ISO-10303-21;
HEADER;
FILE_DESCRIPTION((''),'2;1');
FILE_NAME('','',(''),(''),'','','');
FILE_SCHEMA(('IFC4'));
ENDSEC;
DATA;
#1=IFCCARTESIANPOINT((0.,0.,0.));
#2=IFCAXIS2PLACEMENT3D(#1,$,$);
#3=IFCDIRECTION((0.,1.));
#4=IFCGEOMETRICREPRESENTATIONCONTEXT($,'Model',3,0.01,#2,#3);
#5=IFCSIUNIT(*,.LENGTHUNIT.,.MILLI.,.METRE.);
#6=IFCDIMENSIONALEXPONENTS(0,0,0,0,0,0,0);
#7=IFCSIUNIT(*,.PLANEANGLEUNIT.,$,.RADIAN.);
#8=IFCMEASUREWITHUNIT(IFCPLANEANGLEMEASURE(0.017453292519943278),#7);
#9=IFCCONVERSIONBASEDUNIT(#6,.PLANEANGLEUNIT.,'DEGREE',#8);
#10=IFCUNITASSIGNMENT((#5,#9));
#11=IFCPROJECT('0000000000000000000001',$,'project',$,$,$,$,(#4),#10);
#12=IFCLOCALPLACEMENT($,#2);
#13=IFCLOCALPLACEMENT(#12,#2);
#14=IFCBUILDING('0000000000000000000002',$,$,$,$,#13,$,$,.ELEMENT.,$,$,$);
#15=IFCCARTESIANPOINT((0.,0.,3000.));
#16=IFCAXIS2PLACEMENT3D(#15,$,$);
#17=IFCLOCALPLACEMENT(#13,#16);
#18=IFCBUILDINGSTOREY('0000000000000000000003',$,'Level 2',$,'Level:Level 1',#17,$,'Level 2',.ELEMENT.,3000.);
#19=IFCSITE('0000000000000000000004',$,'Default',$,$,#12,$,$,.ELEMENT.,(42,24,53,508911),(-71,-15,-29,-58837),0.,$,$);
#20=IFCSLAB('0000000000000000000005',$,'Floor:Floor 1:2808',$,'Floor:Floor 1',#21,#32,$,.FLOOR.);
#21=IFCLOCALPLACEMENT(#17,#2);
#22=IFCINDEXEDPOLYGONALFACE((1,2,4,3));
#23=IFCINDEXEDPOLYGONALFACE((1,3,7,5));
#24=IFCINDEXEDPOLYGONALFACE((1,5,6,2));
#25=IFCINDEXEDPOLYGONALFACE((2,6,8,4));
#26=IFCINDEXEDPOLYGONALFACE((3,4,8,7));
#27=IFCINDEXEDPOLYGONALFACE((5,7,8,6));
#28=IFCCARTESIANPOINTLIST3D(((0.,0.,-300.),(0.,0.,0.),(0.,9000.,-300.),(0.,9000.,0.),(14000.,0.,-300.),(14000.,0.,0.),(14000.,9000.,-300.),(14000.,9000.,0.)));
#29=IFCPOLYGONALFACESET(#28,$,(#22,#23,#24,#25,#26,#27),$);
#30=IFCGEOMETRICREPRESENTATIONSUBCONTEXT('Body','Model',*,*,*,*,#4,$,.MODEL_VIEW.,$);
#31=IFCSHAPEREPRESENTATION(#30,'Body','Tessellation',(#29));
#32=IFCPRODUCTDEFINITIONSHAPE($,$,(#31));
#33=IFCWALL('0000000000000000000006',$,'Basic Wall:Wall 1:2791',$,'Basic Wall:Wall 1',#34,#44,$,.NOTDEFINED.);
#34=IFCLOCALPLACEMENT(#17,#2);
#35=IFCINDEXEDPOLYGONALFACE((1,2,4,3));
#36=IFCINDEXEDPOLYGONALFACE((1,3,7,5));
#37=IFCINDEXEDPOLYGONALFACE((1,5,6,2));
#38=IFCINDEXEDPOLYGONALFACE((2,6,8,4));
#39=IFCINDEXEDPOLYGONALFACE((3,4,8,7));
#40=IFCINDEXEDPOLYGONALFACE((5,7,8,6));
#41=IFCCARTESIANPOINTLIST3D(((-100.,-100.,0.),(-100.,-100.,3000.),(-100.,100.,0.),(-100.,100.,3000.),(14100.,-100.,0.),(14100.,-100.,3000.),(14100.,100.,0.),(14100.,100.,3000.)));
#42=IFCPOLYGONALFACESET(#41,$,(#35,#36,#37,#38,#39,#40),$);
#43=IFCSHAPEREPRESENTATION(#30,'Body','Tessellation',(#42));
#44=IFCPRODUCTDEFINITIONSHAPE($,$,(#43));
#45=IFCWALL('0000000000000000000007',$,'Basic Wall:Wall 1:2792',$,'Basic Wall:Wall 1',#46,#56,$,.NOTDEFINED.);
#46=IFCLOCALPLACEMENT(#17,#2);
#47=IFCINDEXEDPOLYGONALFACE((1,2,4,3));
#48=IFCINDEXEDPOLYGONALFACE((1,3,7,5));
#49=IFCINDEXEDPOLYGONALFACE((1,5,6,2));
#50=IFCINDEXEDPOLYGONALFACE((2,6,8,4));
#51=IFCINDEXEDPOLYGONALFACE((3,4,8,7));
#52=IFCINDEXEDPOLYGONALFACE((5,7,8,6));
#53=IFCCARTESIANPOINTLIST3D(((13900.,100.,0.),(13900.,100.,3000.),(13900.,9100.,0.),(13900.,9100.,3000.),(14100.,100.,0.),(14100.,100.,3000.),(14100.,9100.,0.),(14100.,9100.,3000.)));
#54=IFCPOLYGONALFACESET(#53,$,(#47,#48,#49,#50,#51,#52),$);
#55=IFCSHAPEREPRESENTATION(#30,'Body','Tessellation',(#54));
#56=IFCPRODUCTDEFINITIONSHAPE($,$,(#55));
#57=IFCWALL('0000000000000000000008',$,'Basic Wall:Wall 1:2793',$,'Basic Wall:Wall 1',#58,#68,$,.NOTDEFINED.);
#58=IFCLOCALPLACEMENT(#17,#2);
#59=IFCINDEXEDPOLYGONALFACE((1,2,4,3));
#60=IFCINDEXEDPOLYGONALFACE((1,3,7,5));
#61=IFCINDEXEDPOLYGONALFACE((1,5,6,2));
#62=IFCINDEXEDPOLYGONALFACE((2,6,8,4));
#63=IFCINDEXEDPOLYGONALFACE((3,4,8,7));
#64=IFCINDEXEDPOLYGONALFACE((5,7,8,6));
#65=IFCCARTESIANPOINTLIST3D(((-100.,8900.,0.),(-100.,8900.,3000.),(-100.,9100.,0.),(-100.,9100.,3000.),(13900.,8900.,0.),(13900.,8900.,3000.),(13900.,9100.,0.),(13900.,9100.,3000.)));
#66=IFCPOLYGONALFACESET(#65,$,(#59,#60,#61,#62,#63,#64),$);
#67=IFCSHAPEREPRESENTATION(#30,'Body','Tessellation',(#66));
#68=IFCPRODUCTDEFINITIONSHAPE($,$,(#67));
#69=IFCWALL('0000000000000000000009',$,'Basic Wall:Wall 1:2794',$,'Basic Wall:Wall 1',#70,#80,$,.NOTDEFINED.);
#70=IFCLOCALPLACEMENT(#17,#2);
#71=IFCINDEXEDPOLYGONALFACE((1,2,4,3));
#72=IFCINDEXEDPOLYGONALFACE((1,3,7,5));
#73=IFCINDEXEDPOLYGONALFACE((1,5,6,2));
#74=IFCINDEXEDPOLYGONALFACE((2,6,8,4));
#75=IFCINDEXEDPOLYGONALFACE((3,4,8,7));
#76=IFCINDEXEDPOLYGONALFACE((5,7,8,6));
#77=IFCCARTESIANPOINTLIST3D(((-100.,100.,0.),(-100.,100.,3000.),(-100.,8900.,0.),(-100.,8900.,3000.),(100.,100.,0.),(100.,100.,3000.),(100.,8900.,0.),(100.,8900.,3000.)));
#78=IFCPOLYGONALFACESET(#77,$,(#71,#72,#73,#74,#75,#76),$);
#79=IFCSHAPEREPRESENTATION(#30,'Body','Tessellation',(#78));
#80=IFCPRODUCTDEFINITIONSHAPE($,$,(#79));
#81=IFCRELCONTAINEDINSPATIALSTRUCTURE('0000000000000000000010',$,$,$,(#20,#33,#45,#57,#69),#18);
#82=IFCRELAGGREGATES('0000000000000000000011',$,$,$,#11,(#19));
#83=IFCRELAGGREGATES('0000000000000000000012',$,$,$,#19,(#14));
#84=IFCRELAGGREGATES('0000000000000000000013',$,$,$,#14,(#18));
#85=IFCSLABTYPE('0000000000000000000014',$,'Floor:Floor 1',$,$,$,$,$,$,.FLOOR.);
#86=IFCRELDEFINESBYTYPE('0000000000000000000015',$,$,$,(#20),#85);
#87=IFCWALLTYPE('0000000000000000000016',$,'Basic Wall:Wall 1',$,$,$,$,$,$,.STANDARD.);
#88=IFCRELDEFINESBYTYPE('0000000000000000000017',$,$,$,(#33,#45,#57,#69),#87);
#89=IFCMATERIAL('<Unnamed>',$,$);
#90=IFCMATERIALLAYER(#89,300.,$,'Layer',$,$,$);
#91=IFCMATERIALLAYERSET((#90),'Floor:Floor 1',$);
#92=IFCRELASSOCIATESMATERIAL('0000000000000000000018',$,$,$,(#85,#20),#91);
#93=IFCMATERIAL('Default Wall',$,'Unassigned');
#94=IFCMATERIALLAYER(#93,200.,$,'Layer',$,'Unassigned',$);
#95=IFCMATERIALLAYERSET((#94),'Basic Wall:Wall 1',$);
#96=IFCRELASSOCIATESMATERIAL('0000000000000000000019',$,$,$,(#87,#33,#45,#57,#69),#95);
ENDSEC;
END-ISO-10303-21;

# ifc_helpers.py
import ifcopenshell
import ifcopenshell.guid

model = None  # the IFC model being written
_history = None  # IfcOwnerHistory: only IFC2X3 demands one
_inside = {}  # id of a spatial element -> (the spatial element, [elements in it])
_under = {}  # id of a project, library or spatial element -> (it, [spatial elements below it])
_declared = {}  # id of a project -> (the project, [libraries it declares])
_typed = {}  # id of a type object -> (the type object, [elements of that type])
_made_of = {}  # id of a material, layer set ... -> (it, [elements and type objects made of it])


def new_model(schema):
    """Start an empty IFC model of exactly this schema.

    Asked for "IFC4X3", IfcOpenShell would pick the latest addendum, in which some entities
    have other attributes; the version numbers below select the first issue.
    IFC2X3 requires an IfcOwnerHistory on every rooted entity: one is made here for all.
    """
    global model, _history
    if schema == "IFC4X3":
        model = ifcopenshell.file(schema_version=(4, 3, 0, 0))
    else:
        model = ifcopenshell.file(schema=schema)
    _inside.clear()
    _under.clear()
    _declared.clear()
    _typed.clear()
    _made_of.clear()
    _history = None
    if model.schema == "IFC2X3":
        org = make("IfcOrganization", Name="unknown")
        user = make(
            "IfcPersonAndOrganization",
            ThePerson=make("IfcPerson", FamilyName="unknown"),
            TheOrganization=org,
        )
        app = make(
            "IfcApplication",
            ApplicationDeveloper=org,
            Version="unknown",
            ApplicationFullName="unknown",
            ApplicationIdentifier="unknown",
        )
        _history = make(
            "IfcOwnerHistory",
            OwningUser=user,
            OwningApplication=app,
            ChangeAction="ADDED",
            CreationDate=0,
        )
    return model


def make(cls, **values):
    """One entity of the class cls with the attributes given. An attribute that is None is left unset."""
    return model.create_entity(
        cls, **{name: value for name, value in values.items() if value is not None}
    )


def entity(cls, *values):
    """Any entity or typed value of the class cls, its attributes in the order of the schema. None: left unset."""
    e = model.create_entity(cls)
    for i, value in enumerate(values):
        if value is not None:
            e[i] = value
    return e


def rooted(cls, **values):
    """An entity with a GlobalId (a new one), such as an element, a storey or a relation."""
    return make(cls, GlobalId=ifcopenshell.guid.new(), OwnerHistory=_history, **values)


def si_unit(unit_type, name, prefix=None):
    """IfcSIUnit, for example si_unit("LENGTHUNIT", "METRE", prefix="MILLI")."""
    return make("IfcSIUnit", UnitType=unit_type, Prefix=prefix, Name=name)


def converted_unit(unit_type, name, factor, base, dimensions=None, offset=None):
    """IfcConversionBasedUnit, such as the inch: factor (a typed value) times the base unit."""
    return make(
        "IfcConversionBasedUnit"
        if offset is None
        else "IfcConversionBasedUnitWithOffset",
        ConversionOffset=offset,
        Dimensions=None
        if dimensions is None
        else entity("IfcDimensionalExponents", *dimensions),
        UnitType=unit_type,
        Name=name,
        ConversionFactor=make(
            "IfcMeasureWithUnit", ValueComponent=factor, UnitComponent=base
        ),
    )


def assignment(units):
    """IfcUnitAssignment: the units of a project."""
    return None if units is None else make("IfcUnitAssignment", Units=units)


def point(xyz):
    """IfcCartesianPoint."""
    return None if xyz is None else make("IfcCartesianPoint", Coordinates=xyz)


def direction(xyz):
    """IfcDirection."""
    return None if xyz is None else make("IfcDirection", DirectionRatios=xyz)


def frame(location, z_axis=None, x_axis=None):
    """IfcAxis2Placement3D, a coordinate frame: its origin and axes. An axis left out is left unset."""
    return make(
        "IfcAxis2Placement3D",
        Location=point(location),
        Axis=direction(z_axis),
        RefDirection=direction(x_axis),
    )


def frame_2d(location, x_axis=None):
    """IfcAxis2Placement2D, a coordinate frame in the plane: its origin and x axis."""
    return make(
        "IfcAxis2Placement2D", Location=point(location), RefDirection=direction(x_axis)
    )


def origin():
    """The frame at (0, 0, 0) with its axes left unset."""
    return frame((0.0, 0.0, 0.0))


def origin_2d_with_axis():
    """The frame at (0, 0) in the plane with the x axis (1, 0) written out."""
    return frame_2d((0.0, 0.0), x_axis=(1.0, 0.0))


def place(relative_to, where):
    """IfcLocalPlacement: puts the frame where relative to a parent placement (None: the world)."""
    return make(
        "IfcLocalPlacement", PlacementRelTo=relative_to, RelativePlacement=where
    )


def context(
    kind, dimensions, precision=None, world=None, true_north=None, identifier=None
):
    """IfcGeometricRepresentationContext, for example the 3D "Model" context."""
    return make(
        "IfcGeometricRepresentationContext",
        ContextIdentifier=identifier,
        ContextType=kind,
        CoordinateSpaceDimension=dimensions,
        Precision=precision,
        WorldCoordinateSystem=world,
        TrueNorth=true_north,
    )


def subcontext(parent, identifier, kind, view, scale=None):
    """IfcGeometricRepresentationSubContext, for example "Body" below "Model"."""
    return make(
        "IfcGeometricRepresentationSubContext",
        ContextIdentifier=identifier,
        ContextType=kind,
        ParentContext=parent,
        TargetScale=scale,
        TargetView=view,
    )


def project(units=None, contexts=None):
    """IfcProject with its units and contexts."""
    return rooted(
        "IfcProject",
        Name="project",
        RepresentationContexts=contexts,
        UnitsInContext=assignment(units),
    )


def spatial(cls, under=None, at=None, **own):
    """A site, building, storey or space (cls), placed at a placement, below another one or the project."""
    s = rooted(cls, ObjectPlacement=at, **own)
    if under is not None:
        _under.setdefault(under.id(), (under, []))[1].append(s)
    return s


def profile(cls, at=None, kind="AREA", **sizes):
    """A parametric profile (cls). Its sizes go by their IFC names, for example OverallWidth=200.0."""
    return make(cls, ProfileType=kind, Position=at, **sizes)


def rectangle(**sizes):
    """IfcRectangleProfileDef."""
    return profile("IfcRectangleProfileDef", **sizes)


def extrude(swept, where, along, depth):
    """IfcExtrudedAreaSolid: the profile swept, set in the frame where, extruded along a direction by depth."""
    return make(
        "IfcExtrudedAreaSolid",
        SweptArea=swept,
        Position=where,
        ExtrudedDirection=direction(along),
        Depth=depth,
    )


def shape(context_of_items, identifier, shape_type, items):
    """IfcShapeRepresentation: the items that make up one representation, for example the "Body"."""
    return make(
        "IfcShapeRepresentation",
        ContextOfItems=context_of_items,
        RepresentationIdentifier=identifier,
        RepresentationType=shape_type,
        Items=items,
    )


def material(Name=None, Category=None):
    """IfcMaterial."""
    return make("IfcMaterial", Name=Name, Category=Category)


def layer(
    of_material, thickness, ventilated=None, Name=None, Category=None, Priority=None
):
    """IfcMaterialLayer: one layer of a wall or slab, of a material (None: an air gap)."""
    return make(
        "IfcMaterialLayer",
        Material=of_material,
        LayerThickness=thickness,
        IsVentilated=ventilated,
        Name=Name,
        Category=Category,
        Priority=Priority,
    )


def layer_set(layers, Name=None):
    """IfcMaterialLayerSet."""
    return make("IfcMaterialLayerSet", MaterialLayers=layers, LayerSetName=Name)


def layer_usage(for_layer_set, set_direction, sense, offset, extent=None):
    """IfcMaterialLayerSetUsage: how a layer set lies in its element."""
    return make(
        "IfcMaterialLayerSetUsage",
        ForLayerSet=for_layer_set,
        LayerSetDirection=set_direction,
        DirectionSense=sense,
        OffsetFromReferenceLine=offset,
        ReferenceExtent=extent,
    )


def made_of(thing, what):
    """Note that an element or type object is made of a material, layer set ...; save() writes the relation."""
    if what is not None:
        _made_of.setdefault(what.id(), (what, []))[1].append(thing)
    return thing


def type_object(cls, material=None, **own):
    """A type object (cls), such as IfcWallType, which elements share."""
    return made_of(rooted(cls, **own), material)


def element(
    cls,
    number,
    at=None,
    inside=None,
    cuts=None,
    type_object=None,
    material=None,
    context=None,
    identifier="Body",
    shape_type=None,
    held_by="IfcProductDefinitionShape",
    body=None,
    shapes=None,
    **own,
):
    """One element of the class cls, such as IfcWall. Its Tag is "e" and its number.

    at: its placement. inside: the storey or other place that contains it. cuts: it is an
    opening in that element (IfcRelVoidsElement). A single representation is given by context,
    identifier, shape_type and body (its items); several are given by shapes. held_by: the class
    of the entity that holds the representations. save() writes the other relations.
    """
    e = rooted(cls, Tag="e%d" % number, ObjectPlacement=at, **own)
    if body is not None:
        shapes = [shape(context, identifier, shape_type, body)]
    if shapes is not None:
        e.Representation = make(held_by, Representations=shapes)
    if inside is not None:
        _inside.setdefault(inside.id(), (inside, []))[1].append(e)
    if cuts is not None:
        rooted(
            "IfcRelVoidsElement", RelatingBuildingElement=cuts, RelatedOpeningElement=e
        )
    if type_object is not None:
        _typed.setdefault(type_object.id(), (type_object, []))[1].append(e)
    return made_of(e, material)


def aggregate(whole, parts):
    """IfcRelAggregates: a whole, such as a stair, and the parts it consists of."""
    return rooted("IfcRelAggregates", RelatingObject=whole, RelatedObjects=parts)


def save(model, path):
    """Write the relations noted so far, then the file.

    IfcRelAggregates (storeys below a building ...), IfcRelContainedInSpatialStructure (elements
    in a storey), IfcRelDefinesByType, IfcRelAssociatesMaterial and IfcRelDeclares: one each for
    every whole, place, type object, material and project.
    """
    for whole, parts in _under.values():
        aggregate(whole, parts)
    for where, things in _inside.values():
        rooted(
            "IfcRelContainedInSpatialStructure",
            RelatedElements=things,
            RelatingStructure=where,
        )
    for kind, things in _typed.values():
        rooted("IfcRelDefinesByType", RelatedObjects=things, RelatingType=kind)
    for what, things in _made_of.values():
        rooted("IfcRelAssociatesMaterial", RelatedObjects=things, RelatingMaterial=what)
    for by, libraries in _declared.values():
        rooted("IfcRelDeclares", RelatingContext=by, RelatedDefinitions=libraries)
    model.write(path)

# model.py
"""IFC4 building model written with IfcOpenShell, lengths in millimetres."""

from ifc_helpers import new_model, entity, si_unit, converted_unit, direction, frame, frame_2d, origin, origin_2d_with_axis, place, context, subcontext, project, spatial, rectangle, extrude, material, layer, layer_set, layer_usage, type_object, element, save


model = new_model("IFC4")

# Units and contexts
model_context = context("Model", 3, precision=0.01, world=origin(), true_north=direction((0.0, 1.0)))
body_context = subcontext(model_context, "Body", "Model", "MODEL_VIEW")
ifc_project = project(units=[si_unit("LENGTHUNIT", "METRE", prefix="MILLI"), converted_unit("PLANEANGLEUNIT", "DEGREE", entity("IfcPlaneAngleMeasure", 0.017453292519943278), si_unit("PLANEANGLEUNIT", "RADIAN"), dimensions=[0, 0, 0, 0, 0, 0, 0])], contexts=[model_context])

# Site, building, storey
site_placement = place(None, origin())
site = spatial("IfcSite", under=ifc_project, at=site_placement, Name="Default", CompositionType="ELEMENT", RefLatitude=(42, 24, 53, 508911), RefLongitude=(-71, -15, -29, -58837), RefElevation=0.0)
building_placement = place(site_placement, origin())
building = spatial("IfcBuilding", under=site, at=building_placement, CompositionType="ELEMENT")
storey_placement = place(building_placement, frame((0.0, 0.0, 3000.0)))
storey = spatial("IfcBuildingStorey", under=building, at=storey_placement, Name="Level 2", ObjectType="Level:Level 1", LongName="Level 2", CompositionType="ELEMENT", Elevation=3000.0)

# Slab
ifc_material_1 = material(Name="<Unnamed>")
ifc_layer_1 = layer(ifc_material_1, 300.0, Name="Layer")
ifc_layer_set_1 = layer_set([ifc_layer_1], Name="Floor:Floor 1")
ifc_layer_usage_1 = layer_usage(ifc_layer_set_1, "AXIS3", "POSITIVE", 0.0)
slab_type = type_object("IfcSlabType", Name="Floor:Floor 1", PredefinedType="FLOOR", material=ifc_layer_set_1)
slab_placement = place(storey_placement, origin())
element("IfcSlab", 1, at=slab_placement, inside=storey, type_object=slab_type, material=ifc_layer_usage_1, Name="Floor:Floor 1:2808", ObjectType="Floor:Floor 1", PredefinedType="FLOOR", context=body_context, shape_type="SweptSolid", body=[
    extrude(rectangle(XDim=9000.0, YDim=14000.0, at=origin_2d_with_axis()), frame((7000.0, 4500.0, 0.0), z_axis=(0.0, 0.0, -1.0), x_axis=(0.0, 1.0, 0.0)), (0.0, 0.0, 1.0), 300.0),
])

# Walls
ifc_material_2 = material(Name="Default Wall", Category="Unassigned")
ifc_layer_2 = layer(ifc_material_2, 200.0, Name="Layer", Category="Unassigned")
ifc_layer_set_2 = layer_set([ifc_layer_2], Name="Basic Wall:Wall 1")
ifc_layer_usage_2 = layer_usage(ifc_layer_set_2, "AXIS2", "NEGATIVE", 100.0)
wall_type = type_object("IfcWallType", Name="Basic Wall:Wall 1", PredefinedType="STANDARD", material=ifc_layer_set_2)
wall_1_placement = place(storey_placement, frame((-100.0, 0.0, 0.0)))
element("IfcWall", 2, at=wall_1_placement, inside=storey, type_object=wall_type, material=ifc_layer_usage_2, Name="Basic Wall:Wall 1:2791", ObjectType="Basic Wall:Wall 1", PredefinedType="NOTDEFINED", context=body_context, shape_type="SweptSolid", body=[
    extrude(rectangle(XDim=14200.0, YDim=200.0, at=frame_2d((7100.0, 0.0), x_axis=(-1.0, 0.0))), origin(), (0.0, 0.0, 1.0), 3000.0),
])
ifc_layer_usage_3 = layer_usage(ifc_layer_set_2, "AXIS2", "NEGATIVE", 100.0)
wall_2_placement = place(storey_placement, frame((14000.0, 100.0, 0.0), z_axis=(0.0, 0.0, 1.0), x_axis=(0.0, 1.0, 0.0)))
element("IfcWall", 3, at=wall_2_placement, inside=storey, type_object=wall_type, material=ifc_layer_usage_3, Name="Basic Wall:Wall 1:2792", ObjectType="Basic Wall:Wall 1", PredefinedType="NOTDEFINED", context=body_context, shape_type="SweptSolid", body=[
    extrude(rectangle(XDim=9000.0, YDim=200.0, at=frame_2d((4500.0, 0.0), x_axis=(-1.0, 0.0))), origin(), (0.0, 0.0, 1.0), 3000.0),
])
ifc_layer_usage_4 = layer_usage(ifc_layer_set_2, "AXIS2", "NEGATIVE", 100.0)
wall_3_placement = place(storey_placement, frame((13900.0, 9000.0, 0.0), z_axis=(0.0, 0.0, 1.0), x_axis=(-1.0, 0.0, 0.0)))
element("IfcWall", 4, at=wall_3_placement, inside=storey, type_object=wall_type, material=ifc_layer_usage_4, Name="Basic Wall:Wall 1:2793", ObjectType="Basic Wall:Wall 1", PredefinedType="NOTDEFINED", context=body_context, shape_type="SweptSolid", body=[
    extrude(rectangle(XDim=14000.0, YDim=200.0, at=frame_2d((7000.0, 0.0), x_axis=(-1.0, 0.0))), origin(), (0.0, 0.0, 1.0), 3000.0),
])
ifc_layer_usage_5 = layer_usage(ifc_layer_set_2, "AXIS2", "NEGATIVE", 100.0)
wall_4_placement = place(storey_placement, frame((0.0, 8900.0, 0.0), z_axis=(0.0, 0.0, 1.0), x_axis=(0.0, -1.0, 0.0)))
element("IfcWall", 5, at=wall_4_placement, inside=storey, type_object=wall_type, material=ifc_layer_usage_5, Name="Basic Wall:Wall 1:2794", ObjectType="Basic Wall:Wall 1", PredefinedType="NOTDEFINED", context=body_context, shape_type="SweptSolid", body=[
    extrude(rectangle(XDim=8800.0, YDim=200.0, at=frame_2d((4400.0, 0.0), x_axis=(-1.0, 0.0))), origin(), (0.0, 0.0, 1.0), 3000.0),
])

save(model, "model.ifc")
